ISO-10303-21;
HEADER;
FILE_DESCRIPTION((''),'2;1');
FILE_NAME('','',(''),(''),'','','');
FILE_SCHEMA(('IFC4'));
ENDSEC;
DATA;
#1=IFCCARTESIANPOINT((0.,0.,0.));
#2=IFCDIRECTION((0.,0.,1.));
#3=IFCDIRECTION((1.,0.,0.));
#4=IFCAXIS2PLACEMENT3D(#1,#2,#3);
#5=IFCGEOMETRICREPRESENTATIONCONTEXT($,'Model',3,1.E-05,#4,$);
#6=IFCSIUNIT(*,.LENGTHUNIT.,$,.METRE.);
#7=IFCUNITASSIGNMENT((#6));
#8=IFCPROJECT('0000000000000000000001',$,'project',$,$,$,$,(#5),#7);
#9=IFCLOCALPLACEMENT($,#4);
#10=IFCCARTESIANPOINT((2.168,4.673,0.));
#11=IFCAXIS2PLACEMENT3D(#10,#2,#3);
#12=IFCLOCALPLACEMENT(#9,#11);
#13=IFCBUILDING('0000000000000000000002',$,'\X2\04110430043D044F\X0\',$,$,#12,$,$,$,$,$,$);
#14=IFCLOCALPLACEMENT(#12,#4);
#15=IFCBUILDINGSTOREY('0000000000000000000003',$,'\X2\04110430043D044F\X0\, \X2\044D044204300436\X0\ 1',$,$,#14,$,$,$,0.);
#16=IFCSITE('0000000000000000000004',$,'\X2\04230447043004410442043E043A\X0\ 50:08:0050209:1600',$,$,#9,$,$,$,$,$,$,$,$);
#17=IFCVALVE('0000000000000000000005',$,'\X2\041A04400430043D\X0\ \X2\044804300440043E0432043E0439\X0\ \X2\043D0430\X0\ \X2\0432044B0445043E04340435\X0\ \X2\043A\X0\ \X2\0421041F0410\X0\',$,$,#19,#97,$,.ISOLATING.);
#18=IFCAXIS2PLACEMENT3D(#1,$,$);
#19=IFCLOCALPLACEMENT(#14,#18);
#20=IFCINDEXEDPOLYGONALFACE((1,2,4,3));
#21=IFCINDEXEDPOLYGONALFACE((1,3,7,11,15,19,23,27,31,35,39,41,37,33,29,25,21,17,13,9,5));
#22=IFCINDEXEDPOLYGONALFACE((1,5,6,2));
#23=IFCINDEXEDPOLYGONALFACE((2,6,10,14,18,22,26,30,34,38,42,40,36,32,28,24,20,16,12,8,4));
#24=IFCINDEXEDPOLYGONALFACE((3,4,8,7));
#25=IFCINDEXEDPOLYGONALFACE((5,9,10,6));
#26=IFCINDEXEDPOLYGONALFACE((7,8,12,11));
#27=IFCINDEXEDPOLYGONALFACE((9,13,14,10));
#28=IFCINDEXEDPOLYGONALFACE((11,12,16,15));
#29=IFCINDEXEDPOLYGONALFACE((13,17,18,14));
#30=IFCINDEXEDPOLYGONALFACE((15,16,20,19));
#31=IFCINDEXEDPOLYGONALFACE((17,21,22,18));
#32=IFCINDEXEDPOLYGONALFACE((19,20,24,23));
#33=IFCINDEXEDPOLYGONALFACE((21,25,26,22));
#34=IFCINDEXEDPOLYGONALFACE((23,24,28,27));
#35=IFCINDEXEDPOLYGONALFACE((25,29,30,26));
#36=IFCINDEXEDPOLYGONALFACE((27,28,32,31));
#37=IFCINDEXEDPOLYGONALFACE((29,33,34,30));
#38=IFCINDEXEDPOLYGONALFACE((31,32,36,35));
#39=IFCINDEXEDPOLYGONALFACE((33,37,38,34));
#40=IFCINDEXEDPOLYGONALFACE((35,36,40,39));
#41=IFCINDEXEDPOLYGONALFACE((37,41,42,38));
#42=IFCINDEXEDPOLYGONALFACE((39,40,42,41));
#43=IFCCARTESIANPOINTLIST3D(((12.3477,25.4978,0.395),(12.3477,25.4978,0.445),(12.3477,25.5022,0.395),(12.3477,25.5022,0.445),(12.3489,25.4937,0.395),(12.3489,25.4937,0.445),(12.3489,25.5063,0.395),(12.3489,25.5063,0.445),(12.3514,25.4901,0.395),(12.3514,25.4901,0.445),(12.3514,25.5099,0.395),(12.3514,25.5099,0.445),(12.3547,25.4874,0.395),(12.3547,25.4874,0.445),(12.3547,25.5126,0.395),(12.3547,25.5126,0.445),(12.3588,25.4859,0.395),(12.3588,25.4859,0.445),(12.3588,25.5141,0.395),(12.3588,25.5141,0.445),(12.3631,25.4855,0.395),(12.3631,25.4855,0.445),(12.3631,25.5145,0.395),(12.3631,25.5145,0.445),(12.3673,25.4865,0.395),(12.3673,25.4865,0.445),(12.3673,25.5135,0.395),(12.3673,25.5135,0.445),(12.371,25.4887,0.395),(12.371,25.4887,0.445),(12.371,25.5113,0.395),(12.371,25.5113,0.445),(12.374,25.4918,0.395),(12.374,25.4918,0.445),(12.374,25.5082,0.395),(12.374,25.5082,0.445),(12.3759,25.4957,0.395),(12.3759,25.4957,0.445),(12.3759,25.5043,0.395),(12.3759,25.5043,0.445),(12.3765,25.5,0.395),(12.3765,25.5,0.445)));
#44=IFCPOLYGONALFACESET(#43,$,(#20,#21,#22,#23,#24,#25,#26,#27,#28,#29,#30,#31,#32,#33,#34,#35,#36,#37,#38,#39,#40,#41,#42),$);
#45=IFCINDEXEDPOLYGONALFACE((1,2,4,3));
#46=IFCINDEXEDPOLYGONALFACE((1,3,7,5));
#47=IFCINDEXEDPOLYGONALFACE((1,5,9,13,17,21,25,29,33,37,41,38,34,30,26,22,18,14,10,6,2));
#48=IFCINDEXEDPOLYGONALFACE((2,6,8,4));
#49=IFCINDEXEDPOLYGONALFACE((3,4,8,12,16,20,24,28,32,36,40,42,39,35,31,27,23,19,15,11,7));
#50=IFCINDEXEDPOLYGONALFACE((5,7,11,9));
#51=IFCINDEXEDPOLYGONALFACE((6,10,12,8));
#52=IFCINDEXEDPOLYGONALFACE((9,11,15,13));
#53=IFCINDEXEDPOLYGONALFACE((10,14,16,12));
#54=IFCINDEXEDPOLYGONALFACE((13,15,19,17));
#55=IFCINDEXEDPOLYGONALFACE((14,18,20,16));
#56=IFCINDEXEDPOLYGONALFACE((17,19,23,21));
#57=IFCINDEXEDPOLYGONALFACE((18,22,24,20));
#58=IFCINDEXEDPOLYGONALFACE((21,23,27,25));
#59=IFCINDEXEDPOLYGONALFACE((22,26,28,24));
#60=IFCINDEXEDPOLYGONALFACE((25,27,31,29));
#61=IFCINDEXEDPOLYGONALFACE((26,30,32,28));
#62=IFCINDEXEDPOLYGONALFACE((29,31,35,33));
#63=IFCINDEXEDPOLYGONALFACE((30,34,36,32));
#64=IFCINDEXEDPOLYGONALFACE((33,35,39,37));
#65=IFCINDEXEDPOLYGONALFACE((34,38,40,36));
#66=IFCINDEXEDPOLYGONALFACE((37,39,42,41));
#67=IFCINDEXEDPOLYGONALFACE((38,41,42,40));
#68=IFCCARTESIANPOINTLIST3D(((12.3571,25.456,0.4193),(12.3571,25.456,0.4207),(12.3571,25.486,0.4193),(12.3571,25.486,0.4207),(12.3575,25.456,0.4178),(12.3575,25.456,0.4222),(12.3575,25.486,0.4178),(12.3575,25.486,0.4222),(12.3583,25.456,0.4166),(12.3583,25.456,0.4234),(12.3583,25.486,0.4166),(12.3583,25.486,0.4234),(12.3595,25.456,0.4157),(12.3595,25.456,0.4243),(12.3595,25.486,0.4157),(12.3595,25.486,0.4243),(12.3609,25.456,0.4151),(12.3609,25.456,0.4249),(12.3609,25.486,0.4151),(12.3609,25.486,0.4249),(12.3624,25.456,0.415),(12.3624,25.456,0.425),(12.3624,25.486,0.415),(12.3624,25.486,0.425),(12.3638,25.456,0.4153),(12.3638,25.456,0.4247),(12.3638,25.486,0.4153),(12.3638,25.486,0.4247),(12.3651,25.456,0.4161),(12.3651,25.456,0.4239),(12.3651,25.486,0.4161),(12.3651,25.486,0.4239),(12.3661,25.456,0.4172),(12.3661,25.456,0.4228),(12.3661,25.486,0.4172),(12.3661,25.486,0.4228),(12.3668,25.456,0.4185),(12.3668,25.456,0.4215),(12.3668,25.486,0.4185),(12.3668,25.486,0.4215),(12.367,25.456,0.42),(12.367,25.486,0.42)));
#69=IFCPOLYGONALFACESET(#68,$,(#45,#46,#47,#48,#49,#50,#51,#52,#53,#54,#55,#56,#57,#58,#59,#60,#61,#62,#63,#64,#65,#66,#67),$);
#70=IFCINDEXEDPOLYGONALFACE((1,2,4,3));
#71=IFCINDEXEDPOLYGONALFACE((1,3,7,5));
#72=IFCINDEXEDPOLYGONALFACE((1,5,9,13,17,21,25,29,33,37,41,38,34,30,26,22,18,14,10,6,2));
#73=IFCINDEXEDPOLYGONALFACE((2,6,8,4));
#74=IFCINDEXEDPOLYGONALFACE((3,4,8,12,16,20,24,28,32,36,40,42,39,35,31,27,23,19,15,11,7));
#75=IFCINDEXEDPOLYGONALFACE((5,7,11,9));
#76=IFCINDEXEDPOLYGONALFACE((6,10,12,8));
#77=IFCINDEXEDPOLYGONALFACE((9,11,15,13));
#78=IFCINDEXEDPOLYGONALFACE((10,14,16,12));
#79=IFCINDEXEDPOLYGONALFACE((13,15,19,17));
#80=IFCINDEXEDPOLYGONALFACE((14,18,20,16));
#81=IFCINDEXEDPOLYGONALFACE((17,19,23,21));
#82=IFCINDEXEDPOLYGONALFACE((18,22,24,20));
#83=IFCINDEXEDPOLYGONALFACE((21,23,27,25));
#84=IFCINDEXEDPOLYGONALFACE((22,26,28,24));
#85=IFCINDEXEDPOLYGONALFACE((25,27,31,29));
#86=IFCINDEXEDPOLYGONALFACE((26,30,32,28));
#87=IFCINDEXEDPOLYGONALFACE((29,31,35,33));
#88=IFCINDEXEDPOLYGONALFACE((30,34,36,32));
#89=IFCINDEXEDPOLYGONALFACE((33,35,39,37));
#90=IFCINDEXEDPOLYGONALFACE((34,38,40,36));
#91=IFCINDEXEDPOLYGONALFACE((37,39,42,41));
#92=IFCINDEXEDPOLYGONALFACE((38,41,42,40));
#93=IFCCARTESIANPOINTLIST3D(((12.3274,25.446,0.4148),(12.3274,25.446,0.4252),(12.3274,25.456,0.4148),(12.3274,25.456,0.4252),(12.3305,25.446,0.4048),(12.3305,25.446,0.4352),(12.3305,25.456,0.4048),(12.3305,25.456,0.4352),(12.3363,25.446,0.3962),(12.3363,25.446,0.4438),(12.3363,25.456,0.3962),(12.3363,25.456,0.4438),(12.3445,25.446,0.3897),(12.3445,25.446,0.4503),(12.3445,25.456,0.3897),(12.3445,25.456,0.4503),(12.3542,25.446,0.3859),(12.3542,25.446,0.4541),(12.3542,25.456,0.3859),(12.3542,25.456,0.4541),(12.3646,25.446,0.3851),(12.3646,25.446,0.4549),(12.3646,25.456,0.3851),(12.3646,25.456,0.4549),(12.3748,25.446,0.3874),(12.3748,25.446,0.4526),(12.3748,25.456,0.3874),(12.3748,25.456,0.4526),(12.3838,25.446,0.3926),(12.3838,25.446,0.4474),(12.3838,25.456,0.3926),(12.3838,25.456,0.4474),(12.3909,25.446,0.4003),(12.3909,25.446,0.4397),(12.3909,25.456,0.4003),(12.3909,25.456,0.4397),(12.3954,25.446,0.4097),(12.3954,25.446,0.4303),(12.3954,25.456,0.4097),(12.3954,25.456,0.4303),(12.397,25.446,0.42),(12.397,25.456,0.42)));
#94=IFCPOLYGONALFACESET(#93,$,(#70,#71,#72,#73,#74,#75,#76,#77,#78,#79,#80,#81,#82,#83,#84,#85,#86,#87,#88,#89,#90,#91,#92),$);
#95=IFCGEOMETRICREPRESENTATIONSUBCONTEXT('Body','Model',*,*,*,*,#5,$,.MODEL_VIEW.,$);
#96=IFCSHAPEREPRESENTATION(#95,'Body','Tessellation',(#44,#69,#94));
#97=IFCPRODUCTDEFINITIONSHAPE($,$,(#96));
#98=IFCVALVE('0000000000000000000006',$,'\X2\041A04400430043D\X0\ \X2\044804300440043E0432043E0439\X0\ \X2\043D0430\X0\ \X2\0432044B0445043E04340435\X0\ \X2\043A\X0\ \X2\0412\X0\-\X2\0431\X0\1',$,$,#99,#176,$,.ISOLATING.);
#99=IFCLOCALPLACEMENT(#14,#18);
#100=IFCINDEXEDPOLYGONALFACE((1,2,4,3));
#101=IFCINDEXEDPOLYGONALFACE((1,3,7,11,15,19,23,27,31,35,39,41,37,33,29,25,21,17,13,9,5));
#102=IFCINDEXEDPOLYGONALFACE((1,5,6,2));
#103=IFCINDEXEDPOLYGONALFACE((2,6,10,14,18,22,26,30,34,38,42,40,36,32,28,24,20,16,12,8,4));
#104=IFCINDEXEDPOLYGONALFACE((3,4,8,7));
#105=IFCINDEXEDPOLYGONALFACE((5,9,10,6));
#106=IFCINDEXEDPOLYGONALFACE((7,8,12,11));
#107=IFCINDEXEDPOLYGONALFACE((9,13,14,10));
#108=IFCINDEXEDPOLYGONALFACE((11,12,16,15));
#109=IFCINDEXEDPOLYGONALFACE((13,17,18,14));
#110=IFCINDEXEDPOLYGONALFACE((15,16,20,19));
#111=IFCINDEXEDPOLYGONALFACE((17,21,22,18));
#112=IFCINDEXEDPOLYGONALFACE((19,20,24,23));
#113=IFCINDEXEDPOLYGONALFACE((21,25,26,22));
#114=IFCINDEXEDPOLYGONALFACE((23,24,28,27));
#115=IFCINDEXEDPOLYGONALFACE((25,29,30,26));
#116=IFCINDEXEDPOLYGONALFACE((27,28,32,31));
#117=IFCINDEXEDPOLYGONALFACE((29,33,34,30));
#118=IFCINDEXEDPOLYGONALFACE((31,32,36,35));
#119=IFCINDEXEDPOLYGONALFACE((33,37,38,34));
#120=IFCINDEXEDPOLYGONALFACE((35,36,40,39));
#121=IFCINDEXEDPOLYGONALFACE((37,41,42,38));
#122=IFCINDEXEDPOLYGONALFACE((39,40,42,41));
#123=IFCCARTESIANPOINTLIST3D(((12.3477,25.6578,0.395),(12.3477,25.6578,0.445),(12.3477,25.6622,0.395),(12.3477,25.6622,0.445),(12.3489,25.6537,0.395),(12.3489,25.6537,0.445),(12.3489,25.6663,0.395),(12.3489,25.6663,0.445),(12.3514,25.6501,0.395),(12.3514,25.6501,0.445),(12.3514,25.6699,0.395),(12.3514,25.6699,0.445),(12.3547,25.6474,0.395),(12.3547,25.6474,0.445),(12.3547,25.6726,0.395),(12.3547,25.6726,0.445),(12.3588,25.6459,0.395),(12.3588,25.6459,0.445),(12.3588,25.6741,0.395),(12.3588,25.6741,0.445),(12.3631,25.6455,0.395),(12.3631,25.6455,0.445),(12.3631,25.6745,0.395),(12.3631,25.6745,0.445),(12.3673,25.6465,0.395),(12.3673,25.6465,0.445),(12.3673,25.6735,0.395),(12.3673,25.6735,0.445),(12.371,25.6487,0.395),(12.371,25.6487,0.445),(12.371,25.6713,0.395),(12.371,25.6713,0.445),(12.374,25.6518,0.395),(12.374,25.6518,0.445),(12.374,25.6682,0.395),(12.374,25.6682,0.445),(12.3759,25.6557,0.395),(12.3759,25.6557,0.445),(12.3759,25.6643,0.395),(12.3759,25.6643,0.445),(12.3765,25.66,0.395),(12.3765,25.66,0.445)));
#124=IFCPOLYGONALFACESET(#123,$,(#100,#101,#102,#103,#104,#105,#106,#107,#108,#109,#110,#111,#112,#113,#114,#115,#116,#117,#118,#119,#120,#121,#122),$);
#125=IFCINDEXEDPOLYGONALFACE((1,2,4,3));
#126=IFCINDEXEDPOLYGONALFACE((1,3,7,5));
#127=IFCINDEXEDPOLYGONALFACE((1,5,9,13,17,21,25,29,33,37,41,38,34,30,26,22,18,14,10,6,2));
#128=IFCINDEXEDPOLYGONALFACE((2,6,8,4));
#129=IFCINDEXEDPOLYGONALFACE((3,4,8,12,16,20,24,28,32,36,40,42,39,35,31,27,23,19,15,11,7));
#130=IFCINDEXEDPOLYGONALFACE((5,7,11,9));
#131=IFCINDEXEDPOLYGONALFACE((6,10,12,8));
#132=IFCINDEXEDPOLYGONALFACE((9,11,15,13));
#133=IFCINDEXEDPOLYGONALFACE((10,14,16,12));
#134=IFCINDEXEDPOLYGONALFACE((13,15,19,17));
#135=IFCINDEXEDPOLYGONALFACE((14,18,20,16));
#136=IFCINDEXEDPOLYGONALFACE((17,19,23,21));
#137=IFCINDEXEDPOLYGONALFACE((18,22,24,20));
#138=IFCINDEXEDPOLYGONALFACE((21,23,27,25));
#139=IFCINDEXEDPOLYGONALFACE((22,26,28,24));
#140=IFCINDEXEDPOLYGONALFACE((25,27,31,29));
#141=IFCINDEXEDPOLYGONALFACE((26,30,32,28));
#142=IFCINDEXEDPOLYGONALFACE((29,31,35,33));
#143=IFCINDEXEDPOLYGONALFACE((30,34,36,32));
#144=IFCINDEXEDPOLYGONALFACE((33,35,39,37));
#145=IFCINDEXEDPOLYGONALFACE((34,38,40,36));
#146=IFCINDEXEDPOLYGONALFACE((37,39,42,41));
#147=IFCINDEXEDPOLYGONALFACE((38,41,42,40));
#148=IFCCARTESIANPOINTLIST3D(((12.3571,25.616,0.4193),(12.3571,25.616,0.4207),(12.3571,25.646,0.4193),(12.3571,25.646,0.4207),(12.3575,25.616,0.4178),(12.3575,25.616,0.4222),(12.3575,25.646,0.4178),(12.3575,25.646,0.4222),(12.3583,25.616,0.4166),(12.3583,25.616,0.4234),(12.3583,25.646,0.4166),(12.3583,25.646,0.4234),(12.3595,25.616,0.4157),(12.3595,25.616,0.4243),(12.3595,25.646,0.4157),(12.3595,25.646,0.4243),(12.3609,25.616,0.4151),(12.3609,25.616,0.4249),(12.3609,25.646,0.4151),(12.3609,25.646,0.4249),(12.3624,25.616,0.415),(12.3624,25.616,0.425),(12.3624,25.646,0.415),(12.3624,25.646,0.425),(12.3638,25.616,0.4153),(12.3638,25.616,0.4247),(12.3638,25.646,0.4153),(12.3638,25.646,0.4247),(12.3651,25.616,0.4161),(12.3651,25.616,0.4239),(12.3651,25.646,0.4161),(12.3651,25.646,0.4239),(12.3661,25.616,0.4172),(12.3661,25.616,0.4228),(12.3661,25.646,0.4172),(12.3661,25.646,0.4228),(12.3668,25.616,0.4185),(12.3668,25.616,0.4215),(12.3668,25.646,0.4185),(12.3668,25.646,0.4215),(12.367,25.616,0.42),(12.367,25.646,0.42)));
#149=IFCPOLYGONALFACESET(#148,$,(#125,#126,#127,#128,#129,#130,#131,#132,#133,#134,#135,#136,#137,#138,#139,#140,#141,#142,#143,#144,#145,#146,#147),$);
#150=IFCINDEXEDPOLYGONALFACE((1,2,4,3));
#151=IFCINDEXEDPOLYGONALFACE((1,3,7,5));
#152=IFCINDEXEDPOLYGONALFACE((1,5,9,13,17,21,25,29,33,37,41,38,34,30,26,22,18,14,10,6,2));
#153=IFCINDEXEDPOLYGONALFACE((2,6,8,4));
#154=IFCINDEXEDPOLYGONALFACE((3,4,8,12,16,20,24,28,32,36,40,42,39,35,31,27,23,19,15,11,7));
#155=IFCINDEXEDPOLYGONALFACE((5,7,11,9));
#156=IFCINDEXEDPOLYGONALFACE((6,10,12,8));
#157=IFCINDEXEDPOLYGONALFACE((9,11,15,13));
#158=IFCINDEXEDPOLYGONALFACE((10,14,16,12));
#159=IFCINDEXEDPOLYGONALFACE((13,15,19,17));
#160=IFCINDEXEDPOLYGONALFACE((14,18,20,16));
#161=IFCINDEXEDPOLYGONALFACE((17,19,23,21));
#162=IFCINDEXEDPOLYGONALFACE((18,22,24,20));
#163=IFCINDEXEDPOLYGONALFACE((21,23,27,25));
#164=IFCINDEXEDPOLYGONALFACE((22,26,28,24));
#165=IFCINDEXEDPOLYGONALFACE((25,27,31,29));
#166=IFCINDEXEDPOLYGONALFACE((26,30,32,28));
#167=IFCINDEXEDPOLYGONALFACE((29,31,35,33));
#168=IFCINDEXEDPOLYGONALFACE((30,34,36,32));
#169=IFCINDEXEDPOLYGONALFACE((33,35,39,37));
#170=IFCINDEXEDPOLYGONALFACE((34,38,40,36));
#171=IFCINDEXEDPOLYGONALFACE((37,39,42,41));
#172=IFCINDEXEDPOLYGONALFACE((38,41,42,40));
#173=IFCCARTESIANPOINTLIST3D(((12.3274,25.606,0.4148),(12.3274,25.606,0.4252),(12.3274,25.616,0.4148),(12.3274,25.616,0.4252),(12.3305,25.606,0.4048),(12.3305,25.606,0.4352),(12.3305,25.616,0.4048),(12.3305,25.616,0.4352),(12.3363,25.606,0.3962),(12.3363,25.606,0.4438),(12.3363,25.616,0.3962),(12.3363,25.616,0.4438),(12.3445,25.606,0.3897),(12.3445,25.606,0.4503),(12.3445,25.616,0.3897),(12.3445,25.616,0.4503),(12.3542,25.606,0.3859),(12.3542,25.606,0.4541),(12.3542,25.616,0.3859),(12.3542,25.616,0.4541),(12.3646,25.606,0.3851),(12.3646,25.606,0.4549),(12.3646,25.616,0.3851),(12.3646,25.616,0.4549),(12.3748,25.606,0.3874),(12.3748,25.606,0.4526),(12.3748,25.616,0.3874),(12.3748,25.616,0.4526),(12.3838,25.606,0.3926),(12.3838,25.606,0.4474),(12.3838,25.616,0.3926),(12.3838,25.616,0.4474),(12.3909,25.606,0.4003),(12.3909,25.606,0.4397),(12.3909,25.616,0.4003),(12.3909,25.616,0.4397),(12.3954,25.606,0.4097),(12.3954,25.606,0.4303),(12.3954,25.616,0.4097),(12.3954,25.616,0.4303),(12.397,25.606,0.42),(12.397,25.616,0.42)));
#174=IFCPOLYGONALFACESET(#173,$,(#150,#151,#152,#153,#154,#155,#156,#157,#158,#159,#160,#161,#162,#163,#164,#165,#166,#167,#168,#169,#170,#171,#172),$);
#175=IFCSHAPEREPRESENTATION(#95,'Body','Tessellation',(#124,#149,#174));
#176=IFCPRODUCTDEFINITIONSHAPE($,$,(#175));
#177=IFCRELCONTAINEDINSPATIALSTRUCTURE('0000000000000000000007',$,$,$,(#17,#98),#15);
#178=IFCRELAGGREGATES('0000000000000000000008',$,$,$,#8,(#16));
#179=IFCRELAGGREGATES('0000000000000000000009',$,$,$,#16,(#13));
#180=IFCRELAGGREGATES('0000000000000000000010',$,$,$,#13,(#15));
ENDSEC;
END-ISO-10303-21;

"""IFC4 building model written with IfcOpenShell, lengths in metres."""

from ifc_helpers import new_model, si_unit, frame, origin_with_axes, origin_2d, place, context, subcontext, project, spatial, circle, extrude, element, save


model = new_model("IFC4")

# Units and contexts
model_context = context("Model", 3, precision=1e-05, world=origin_with_axes())
body_context = subcontext(model_context, "Body", "Model", "MODEL_VIEW")
ifc_project = project(units=[si_unit("LENGTHUNIT", "METRE")], contexts=[model_context])

# Site, building, storey
site_placement = place(None, origin_with_axes())
site = spatial("IfcSite", under=ifc_project, at=site_placement, Name="Участок 50:08:0050209:1600")
building_placement = place(site_placement, frame((2.168, 4.673, 0.0), z_axis=(0.0, 0.0, 1.0), x_axis=(1.0, 0.0, 0.0)))
building = spatial("IfcBuilding", under=site, at=building_placement, Name="Баня")
storey_placement = place(building_placement, origin_with_axes())
storey = spatial("IfcBuildingStorey", under=building, at=storey_placement, Name="Баня, этаж 1", Elevation=0.0)

# Valves
valve_1_placement = place(storey_placement, origin_with_axes())
element("IfcValve", 1, at=valve_1_placement, inside=storey, Name="Кран шаровой на выходе к СПА", PredefinedType="ISOLATING", context=body_context, shape_type="SweptSolid", body=[
    extrude(circle(Radius=0.0145, at=origin_2d()), frame((12.362, 25.5, 0.395), z_axis=(0.0, 0.0, 1.0), x_axis=(1.0, 0.0, 0.0)), (0.0, 0.0, 1.0), 0.05),
    extrude(circle(Radius=0.005, at=origin_2d()), frame((12.362, 25.486, 0.42), z_axis=(0.0, -1.0, 0.0), x_axis=(1.0, 0.0, 0.0)), (0.0, 0.0, 1.0), 0.03),
    extrude(circle(Radius=0.035, at=origin_2d()), frame((12.362, 25.456, 0.42), z_axis=(0.0, -1.0, 0.0), x_axis=(1.0, 0.0, 0.0)), (0.0, 0.0, 1.0), 0.01),
])
valve_2_placement = place(storey_placement, origin_with_axes())
element("IfcValve", 2, at=valve_2_placement, inside=storey, Name="Кран шаровой на выходе к В-б1", PredefinedType="ISOLATING", context=body_context, shape_type="SweptSolid", body=[
    extrude(circle(Radius=0.0145, at=origin_2d()), frame((12.362, 25.66, 0.395), z_axis=(0.0, 0.0, 1.0), x_axis=(1.0, 0.0, 0.0)), (0.0, 0.0, 1.0), 0.05),
    extrude(circle(Radius=0.005, at=origin_2d()), frame((12.362, 25.646, 0.42), z_axis=(0.0, -1.0, 0.0), x_axis=(1.0, 0.0, 0.0)), (0.0, 0.0, 1.0), 0.03),
    extrude(circle(Radius=0.035, at=origin_2d()), frame((12.362, 25.616, 0.42), z_axis=(0.0, -1.0, 0.0), x_axis=(1.0, 0.0, 0.0)), (0.0, 0.0, 1.0), 0.01),
])

save(model, "model.ifc")
